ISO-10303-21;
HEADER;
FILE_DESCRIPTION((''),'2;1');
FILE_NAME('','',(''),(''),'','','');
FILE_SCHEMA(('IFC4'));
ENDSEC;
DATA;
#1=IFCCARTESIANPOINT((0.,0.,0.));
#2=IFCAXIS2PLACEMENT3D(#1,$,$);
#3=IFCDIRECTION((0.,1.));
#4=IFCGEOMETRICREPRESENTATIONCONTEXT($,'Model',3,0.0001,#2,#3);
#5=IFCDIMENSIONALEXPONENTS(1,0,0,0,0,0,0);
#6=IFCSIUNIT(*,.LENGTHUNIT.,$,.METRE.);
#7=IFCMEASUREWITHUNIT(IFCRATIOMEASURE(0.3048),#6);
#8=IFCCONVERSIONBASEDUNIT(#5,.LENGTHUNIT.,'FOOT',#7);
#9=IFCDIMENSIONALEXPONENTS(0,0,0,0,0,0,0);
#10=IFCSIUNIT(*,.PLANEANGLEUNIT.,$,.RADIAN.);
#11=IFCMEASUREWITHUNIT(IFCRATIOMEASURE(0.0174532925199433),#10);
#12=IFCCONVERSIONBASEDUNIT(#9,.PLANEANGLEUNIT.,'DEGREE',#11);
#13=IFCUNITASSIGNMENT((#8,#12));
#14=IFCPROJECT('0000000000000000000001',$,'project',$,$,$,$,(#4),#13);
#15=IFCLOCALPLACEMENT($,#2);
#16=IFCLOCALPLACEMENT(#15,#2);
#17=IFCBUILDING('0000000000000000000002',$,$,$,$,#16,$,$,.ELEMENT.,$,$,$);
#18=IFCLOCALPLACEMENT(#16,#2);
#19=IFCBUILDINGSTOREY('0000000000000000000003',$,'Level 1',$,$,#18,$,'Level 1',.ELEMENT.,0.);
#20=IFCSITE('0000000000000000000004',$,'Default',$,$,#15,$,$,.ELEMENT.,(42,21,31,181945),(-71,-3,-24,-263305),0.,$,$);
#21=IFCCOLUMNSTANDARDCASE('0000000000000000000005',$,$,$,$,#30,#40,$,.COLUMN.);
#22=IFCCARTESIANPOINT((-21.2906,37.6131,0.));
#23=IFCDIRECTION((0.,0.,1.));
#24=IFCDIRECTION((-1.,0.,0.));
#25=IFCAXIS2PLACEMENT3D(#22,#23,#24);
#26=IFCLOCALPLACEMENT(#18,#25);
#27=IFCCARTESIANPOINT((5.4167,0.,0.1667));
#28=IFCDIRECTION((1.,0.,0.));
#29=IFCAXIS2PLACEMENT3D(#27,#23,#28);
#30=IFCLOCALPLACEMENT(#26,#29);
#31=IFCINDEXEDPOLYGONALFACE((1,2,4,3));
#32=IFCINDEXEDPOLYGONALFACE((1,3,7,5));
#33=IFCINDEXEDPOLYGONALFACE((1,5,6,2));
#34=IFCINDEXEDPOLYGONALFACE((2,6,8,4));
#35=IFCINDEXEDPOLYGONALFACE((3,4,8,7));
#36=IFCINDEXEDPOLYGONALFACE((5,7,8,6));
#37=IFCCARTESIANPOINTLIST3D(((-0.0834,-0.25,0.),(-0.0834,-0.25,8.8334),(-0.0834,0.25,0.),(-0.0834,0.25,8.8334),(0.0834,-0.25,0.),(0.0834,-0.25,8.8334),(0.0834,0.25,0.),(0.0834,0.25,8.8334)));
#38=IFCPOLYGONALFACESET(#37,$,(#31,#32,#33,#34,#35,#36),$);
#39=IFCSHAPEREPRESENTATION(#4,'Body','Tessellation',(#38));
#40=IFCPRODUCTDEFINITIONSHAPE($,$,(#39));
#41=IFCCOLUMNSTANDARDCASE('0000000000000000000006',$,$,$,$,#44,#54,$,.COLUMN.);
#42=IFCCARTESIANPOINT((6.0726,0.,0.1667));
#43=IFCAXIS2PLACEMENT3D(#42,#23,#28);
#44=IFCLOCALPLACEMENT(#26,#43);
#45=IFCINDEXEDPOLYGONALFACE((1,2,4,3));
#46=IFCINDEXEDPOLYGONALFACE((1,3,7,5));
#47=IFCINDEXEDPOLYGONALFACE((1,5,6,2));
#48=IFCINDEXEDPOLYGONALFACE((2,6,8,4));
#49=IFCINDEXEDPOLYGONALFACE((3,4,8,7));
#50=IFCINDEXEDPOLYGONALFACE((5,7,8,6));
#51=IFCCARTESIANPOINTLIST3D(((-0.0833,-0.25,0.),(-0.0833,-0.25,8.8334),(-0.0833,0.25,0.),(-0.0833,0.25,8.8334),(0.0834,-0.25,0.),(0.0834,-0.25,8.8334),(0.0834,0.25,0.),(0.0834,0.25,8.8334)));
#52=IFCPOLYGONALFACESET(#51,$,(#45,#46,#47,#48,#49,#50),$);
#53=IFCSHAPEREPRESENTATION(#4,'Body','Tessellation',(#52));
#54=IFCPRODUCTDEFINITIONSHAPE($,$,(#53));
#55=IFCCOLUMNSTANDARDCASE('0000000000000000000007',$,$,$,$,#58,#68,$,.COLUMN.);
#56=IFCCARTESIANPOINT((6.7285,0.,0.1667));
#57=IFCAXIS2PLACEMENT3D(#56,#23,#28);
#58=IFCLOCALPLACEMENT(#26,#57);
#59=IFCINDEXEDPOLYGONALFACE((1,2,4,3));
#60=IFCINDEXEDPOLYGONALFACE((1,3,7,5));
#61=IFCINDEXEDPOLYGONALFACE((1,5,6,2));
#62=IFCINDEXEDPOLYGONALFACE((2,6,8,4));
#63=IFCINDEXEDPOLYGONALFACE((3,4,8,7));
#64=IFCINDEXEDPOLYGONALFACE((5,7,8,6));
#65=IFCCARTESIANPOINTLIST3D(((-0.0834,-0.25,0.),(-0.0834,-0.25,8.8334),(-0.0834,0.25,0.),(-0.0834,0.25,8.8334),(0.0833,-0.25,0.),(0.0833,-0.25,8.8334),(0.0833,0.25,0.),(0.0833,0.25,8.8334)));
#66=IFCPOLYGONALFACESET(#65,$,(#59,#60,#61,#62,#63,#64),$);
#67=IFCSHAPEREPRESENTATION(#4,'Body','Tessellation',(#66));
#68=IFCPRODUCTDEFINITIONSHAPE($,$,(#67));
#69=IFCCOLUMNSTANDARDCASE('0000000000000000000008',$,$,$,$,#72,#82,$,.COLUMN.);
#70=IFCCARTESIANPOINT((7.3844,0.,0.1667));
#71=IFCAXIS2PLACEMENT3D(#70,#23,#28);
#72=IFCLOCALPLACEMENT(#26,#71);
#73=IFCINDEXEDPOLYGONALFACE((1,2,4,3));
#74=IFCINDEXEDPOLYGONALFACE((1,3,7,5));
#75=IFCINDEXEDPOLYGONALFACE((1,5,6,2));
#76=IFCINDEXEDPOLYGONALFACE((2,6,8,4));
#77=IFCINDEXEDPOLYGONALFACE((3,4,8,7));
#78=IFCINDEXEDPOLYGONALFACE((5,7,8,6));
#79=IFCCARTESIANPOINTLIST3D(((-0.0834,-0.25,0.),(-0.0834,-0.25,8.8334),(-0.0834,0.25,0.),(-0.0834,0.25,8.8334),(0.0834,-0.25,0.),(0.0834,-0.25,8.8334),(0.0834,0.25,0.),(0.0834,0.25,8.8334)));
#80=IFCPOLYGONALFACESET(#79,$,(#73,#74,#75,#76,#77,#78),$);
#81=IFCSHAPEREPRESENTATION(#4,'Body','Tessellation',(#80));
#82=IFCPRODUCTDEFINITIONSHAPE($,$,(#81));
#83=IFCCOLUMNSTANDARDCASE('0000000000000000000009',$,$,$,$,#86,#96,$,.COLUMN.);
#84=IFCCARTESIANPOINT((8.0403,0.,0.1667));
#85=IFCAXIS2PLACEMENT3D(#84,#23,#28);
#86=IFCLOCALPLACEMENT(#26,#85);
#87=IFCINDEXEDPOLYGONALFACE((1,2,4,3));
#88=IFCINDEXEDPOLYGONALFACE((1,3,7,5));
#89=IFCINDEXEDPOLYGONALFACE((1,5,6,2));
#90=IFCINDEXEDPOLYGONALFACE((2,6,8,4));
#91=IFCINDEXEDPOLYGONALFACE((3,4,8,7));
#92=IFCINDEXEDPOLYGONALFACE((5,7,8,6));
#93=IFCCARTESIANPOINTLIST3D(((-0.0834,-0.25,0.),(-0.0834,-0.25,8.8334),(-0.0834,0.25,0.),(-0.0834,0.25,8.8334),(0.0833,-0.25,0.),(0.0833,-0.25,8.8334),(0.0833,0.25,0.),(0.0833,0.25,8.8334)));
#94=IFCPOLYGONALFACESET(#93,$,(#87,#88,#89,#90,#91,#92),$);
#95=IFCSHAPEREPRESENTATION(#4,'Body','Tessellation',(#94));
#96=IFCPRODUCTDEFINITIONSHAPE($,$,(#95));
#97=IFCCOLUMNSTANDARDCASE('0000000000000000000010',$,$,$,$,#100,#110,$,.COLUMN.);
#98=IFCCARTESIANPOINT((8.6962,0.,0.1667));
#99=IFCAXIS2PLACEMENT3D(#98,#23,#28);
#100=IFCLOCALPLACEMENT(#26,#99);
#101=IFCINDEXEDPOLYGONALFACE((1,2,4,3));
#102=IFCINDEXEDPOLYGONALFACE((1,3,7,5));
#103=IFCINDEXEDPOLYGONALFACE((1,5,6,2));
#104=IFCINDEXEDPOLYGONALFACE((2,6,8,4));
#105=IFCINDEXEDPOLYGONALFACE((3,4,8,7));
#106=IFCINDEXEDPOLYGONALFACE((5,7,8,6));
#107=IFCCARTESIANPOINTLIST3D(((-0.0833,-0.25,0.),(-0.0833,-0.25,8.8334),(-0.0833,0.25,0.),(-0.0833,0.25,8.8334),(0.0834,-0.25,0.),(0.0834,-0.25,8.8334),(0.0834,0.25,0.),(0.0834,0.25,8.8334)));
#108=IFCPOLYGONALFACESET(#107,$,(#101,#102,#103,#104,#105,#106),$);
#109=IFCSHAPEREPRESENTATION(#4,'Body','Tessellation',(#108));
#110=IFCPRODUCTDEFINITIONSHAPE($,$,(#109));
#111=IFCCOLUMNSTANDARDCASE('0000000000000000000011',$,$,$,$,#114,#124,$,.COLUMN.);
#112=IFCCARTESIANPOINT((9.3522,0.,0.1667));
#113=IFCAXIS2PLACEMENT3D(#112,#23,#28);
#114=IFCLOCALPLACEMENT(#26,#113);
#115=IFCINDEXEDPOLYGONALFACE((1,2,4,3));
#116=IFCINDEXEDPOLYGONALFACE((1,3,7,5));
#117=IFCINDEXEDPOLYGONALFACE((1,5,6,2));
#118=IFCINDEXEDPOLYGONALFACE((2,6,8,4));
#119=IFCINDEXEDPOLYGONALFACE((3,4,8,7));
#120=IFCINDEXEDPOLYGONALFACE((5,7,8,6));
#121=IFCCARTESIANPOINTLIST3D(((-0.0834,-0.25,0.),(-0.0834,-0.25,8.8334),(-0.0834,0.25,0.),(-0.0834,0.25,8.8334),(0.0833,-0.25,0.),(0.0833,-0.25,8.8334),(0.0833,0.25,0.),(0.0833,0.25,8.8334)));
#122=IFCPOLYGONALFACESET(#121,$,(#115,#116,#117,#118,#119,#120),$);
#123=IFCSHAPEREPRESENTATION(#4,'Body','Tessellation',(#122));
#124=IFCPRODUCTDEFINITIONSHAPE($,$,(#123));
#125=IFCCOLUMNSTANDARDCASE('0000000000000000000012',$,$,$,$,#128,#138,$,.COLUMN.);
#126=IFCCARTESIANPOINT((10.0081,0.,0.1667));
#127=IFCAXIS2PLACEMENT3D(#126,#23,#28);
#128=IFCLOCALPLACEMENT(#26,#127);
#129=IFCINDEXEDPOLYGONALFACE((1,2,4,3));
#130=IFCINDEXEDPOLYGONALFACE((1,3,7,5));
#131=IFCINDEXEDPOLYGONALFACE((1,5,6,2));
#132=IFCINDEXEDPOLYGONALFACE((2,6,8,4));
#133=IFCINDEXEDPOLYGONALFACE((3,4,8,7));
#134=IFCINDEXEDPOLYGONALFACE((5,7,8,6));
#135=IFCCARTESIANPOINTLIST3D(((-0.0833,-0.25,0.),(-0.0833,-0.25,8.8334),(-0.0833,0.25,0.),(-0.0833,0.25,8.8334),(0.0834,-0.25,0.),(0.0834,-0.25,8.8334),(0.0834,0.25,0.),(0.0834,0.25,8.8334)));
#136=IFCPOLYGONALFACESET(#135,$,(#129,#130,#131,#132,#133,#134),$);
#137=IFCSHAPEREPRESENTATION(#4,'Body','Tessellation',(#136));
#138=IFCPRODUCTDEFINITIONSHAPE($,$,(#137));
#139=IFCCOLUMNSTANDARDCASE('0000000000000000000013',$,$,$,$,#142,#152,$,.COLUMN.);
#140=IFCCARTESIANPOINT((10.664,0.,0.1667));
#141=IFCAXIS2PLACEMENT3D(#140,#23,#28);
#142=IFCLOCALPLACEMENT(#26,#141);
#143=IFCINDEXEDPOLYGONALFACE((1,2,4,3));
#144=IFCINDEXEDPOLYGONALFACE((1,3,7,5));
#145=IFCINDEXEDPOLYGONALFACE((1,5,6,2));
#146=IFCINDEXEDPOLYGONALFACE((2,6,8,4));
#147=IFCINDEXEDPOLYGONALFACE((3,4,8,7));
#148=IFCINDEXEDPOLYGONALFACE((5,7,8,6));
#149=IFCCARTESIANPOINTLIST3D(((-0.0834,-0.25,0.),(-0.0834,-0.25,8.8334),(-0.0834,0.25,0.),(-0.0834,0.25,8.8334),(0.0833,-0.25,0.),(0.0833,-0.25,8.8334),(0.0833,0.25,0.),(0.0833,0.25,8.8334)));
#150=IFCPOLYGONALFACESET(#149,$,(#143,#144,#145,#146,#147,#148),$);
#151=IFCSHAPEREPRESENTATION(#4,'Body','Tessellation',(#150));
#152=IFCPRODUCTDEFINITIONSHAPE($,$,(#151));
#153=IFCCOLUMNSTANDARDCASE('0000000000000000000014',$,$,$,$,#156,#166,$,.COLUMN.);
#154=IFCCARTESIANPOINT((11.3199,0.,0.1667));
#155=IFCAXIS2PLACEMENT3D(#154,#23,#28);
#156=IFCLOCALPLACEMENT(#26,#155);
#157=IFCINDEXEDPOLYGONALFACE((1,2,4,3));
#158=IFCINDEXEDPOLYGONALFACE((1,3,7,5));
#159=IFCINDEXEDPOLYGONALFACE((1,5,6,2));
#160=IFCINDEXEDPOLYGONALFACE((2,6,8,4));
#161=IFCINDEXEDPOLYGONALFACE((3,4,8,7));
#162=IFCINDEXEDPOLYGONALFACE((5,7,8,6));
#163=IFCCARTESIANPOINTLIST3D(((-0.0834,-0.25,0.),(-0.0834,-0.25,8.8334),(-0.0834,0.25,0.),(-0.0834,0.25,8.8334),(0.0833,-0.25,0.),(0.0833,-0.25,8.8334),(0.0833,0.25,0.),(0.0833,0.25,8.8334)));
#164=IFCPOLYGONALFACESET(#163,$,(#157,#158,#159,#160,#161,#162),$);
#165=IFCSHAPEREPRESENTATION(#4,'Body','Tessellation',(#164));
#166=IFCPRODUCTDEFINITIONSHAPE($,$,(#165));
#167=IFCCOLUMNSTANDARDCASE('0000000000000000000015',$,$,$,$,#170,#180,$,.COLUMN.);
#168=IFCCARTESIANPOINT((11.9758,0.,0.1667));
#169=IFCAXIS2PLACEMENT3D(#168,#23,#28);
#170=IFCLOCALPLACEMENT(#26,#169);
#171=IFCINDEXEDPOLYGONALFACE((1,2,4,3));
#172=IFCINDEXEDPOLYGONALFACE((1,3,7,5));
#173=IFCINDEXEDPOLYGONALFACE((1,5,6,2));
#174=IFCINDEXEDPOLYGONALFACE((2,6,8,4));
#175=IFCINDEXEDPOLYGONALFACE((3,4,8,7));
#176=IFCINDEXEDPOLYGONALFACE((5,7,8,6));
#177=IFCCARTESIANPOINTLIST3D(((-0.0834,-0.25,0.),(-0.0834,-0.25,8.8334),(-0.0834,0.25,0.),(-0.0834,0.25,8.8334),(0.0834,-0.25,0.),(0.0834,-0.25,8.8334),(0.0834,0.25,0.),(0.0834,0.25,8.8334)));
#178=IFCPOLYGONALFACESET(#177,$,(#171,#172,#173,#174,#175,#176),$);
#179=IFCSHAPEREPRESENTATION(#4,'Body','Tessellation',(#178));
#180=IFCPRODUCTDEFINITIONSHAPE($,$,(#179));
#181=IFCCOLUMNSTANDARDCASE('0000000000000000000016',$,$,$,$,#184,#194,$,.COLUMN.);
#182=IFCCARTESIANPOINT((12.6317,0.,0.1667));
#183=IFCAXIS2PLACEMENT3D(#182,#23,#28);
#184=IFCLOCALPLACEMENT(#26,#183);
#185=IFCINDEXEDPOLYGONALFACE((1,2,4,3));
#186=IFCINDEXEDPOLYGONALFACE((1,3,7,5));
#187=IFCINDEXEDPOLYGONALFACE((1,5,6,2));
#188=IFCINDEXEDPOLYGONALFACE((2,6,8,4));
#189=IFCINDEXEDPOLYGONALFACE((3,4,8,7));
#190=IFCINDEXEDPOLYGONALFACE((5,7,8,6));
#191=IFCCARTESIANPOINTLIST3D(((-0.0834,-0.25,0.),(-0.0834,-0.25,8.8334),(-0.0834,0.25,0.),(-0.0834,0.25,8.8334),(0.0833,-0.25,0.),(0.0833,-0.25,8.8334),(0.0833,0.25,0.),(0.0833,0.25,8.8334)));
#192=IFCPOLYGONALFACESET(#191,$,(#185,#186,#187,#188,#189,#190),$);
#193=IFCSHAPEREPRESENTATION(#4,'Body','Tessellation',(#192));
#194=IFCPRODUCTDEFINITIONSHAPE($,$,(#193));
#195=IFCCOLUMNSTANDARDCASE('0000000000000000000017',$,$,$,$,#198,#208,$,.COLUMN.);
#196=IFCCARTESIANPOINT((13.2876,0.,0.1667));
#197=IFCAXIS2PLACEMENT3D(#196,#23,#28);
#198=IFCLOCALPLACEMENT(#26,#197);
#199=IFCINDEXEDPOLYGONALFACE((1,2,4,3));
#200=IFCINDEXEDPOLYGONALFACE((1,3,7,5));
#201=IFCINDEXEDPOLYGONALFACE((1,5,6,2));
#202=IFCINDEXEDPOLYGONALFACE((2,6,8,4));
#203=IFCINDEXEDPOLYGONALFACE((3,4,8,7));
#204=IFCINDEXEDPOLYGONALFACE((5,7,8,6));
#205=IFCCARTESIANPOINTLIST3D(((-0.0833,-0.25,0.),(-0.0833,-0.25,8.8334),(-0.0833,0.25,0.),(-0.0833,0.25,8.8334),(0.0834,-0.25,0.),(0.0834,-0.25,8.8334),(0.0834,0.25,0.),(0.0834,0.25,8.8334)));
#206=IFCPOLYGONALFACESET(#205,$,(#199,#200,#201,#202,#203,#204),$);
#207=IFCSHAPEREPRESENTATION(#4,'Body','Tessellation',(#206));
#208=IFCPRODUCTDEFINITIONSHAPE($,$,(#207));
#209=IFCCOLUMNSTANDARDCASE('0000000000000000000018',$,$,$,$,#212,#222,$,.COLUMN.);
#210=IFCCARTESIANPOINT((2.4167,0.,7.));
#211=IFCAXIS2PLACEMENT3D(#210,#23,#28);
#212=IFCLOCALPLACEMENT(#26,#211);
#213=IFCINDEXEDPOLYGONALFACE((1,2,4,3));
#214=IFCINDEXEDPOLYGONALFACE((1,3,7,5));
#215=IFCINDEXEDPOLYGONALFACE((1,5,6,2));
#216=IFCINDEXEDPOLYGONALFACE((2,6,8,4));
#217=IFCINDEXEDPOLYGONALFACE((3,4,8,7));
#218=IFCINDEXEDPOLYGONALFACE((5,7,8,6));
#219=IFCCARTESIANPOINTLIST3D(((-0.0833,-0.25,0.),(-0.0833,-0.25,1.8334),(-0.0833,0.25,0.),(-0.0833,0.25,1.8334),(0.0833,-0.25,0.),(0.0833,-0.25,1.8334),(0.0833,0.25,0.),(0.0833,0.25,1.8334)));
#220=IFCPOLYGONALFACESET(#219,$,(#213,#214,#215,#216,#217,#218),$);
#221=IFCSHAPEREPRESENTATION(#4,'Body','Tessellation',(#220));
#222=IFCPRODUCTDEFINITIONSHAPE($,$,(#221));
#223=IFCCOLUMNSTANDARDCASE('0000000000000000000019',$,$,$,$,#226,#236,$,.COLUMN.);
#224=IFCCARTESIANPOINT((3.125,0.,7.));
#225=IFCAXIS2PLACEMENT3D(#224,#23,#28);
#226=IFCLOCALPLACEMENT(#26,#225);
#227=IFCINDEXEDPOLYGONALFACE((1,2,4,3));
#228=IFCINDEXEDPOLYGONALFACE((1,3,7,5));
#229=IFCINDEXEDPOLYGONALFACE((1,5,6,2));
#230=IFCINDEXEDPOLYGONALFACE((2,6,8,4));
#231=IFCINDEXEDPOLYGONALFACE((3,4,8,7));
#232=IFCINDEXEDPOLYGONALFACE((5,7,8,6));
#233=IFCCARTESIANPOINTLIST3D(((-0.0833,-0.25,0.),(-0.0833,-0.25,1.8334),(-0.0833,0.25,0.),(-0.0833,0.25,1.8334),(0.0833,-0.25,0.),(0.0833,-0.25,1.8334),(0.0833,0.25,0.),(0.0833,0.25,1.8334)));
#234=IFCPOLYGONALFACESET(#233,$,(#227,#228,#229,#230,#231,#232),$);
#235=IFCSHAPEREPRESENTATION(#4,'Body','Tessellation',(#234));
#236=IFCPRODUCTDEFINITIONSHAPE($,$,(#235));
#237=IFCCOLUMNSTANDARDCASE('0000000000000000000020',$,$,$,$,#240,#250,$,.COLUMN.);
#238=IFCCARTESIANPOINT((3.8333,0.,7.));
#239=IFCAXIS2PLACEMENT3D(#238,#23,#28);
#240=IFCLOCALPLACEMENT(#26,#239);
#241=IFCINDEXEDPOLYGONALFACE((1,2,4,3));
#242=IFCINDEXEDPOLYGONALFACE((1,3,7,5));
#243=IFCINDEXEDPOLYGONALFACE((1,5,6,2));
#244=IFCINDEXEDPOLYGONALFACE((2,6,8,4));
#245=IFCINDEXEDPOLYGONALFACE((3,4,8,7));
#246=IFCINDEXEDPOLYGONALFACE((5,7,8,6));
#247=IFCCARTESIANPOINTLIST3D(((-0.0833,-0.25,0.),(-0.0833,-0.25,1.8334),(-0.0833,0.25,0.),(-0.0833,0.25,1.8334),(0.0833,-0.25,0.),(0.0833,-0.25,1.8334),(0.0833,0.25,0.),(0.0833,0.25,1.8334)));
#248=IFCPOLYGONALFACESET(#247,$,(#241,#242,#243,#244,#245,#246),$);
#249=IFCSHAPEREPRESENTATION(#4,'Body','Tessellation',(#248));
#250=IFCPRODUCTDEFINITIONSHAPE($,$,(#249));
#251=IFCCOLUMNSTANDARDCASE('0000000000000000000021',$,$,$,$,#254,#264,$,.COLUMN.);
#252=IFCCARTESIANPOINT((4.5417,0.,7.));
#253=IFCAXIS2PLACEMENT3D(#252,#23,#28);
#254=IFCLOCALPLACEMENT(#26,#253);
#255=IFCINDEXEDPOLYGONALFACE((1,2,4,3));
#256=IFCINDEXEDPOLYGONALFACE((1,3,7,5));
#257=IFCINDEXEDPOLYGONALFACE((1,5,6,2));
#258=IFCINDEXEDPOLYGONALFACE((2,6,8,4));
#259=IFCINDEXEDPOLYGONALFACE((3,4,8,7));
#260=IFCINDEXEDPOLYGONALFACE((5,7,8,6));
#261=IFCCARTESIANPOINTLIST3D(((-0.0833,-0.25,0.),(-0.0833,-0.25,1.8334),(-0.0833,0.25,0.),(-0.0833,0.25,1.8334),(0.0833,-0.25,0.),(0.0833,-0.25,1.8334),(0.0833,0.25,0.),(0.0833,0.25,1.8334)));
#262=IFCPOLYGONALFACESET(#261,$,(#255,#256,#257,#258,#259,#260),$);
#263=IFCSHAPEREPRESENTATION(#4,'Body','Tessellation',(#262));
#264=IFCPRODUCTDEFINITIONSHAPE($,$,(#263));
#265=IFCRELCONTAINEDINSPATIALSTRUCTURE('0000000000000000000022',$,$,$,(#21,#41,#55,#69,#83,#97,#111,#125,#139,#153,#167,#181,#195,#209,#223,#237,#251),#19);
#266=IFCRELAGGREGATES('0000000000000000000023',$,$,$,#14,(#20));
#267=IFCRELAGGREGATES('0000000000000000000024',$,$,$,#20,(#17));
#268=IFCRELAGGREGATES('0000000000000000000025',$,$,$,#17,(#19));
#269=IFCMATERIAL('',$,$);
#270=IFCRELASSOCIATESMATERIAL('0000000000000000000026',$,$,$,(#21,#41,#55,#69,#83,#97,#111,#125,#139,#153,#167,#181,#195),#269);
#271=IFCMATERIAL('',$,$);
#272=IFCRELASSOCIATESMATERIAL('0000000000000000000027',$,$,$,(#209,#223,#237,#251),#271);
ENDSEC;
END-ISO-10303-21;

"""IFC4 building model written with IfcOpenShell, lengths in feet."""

from ifc_helpers import new_model, entity, si_unit, converted_unit, direction, frame, origin, place, context, project, spatial, rectangle, extrude, material, element, save


model = new_model("IFC4")

# Units and contexts
model_context = context("Model", 3, precision=0.0001, world=origin(), true_north=direction((0.0, 1.0)))
ifc_project = project(units=[converted_unit("LENGTHUNIT", "FOOT", entity("IfcRatioMeasure", 0.3048), si_unit("LENGTHUNIT", "METRE"), dimensions=[1, 0, 0, 0, 0, 0, 0]), converted_unit("PLANEANGLEUNIT", "DEGREE", entity("IfcRatioMeasure", 0.0174532925199433), si_unit("PLANEANGLEUNIT", "RADIAN"), dimensions=[0, 0, 0, 0, 0, 0, 0])], contexts=[model_context])

# Site, building, storey
site_placement = place(None, origin())
site = spatial("IfcSite", under=ifc_project, at=site_placement, Name="Default", CompositionType="ELEMENT", RefLatitude=(42, 21, 31, 181945), RefLongitude=(-71, -3, -24, -263305), RefElevation=0.0)
building_placement = place(site_placement, origin())
building = spatial("IfcBuilding", under=site, at=building_placement, CompositionType="ELEMENT")
storey_placement = place(building_placement, origin())
storey = spatial("IfcBuildingStorey", under=building, at=storey_placement, Name="Level 1", LongName="Level 1", CompositionType="ELEMENT", Elevation=0.0)

# Columns
ifc_material_1 = material(Name="")
placement_1 = place(storey_placement, frame((-21.2906, 37.6131, 0.0), z_axis=(0.0, 0.0, 1.0), x_axis=(-1.0, 0.0, 0.0)))
for number, where, z_axis, x_axis in (
    (1, (5.4167, 0.0, 0.1667), (0.0, 0.0, 1.0), (1.0, 0.0, 0.0)),
    (2, (6.0726, 0.0, 0.1667), (0.0, 0.0, 1.0), (1.0, 0.0, 0.0)),
    (3, (6.7285, 0.0, 0.1667), (0.0, 0.0, 1.0), (1.0, 0.0, 0.0)),
    (4, (7.3844, 0.0, 0.1667), (0.0, 0.0, 1.0), (1.0, 0.0, 0.0)),
    (5, (8.0403, 0.0, 0.1667), (0.0, 0.0, 1.0), (1.0, 0.0, 0.0)),
    (6, (8.6962, 0.0, 0.1667), (0.0, 0.0, 1.0), (1.0, 0.0, 0.0)),
    (7, (9.3522, 0.0, 0.1667), (0.0, 0.0, 1.0), (1.0, 0.0, 0.0)),
    (8, (10.0081, 0.0, 0.1667), (0.0, 0.0, 1.0), (1.0, 0.0, 0.0)),
    (9, (10.664, 0.0, 0.1667), (0.0, 0.0, 1.0), (1.0, 0.0, 0.0)),
    (10, (11.3199, 0.0, 0.1667), (0.0, 0.0, 1.0), (1.0, 0.0, 0.0)),
    (11, (11.9758, 0.0, 0.1667), (0.0, 0.0, 1.0), (1.0, 0.0, 0.0)),
    (12, (12.6317, 0.0, 0.1667), (0.0, 0.0, 1.0), (1.0, 0.0, 0.0)),
    (13, (13.2876, 0.0, 0.1667), (0.0, 0.0, 1.0), (1.0, 0.0, 0.0)),
):
    element("IfcColumnStandardCase", number, at=place(placement_1, frame(where, z_axis=z_axis, x_axis=x_axis)), inside=storey, material=ifc_material_1, PredefinedType="COLUMN", context=model_context, shape_type="SweptSolid", body=[
        extrude(rectangle(XDim=0.1667, YDim=0.5), origin(), (0.0, 0.0, 1.0), 8.8334),
    ])
ifc_material_2 = material(Name="")
for number, where, z_axis, x_axis in (
    (14, (2.4167, 0.0, 7.0), (0.0, 0.0, 1.0), (1.0, 0.0, 0.0)),
    (15, (3.125, 0.0, 7.0), (0.0, 0.0, 1.0), (1.0, 0.0, 0.0)),
    (16, (3.8333, 0.0, 7.0), (0.0, 0.0, 1.0), (1.0, 0.0, 0.0)),
    (17, (4.5417, 0.0, 7.0), (0.0, 0.0, 1.0), (1.0, 0.0, 0.0)),
):
    element("IfcColumnStandardCase", number, at=place(placement_1, frame(where, z_axis=z_axis, x_axis=x_axis)), inside=storey, material=ifc_material_2, PredefinedType="COLUMN", context=model_context, shape_type="SweptSolid", body=[
        extrude(rectangle(XDim=0.1667, YDim=0.5), origin(), (0.0, 0.0, 1.0), 1.8334),
    ])

save(model, "model.ifc")
